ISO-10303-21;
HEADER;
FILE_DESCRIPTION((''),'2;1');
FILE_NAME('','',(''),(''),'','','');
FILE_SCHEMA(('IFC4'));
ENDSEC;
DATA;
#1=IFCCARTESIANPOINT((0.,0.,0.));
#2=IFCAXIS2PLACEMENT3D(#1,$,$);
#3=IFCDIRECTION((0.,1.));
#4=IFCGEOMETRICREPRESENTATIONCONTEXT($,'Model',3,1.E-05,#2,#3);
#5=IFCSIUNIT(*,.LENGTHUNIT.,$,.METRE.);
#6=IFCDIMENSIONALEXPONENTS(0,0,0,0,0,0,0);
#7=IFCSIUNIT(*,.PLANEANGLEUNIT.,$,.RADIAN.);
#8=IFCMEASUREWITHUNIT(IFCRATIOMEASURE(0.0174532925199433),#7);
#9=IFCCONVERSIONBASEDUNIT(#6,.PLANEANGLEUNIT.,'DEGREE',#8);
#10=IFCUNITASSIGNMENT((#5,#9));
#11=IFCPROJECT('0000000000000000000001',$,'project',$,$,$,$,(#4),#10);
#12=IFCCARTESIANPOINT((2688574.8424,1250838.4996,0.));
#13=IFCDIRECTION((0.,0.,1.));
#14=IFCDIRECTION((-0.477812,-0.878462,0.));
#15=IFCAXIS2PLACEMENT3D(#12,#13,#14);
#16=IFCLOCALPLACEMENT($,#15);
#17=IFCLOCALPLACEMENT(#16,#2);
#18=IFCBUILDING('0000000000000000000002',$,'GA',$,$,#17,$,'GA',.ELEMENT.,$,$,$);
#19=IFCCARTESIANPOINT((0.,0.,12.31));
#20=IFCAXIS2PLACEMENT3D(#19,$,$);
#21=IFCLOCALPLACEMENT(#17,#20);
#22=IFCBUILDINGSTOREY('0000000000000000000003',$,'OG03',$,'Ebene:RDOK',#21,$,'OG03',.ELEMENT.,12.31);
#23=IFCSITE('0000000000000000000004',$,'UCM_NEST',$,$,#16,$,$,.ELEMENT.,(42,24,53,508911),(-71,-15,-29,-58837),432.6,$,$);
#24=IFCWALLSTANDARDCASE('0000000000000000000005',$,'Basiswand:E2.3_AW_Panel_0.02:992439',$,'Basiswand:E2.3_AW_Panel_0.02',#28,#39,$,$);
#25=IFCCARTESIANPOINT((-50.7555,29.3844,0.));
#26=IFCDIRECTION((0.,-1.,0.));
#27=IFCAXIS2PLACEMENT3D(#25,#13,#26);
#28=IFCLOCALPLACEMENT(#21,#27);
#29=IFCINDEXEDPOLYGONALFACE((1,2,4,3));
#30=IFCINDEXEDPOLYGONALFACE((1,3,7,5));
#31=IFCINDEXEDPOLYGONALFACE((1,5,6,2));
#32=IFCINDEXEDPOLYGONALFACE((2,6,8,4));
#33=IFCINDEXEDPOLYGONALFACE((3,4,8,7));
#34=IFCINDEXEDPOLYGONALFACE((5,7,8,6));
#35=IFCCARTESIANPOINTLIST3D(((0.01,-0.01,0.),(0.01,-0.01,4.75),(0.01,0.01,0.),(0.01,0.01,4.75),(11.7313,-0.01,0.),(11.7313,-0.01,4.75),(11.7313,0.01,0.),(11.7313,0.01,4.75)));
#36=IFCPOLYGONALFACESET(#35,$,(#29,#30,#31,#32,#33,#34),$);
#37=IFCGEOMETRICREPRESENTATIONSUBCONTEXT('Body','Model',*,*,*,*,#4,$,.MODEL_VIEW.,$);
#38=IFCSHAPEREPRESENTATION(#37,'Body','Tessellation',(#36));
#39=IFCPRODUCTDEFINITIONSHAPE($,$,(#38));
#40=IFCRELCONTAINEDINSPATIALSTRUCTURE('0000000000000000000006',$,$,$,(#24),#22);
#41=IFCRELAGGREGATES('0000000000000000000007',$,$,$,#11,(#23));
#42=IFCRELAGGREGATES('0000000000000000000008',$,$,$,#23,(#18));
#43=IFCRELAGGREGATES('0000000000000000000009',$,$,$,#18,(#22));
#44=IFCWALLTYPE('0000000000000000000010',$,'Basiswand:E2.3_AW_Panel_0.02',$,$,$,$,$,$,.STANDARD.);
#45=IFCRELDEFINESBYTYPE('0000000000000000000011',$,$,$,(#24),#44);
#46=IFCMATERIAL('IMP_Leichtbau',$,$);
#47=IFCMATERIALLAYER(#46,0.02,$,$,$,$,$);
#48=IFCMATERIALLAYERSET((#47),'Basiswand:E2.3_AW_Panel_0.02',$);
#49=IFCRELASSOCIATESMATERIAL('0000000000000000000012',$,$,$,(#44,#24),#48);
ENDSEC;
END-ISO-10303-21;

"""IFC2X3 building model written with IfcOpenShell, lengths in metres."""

from ifc_helpers import new_model, entity, si_unit, converted_unit, direction, frame, frame_2d, origin, place, context, subcontext, project, spatial, rectangle, extrude, material, layer, layer_set, layer_usage, type_object, element, save


model = new_model("IFC2X3")

# Units and contexts
model_context = context("Model", 3, precision=1e-05, world=origin(), true_north=direction((0.0, 1.0)))
body_context = subcontext(model_context, "Body", "Model", "MODEL_VIEW")
ifc_project = project(units=[si_unit("LENGTHUNIT", "METRE"), converted_unit("PLANEANGLEUNIT", "DEGREE", entity("IfcRatioMeasure", 0.0174532925199433), si_unit("PLANEANGLEUNIT", "RADIAN"), dimensions=[0, 0, 0, 0, 0, 0, 0])], contexts=[model_context])

# Site, building, storey
site_placement = place(None, frame((2688574.8424, 1250838.4996, 0.0), z_axis=(0.0, 0.0, 1.0), x_axis=(-0.477812, -0.878462, 0.0)))
site = spatial("IfcSite", under=ifc_project, at=site_placement, Name="UCM_NEST", CompositionType="ELEMENT", RefLatitude=(42, 24, 53, 508911), RefLongitude=(-71, -15, -29, -58837), RefElevation=432.6)
building_placement = place(site_placement, origin())
building = spatial("IfcBuilding", under=site, at=building_placement, Name="GA", LongName="GA", CompositionType="ELEMENT")
storey_placement = place(building_placement, frame((0.0, 0.0, 12.31)))
storey = spatial("IfcBuildingStorey", under=building, at=storey_placement, Name="OG03", ObjectType="Ebene:RDOK", LongName="OG03", CompositionType="ELEMENT", Elevation=12.31)

# Wall
ifc_material_1 = material(Name="IMP_Leichtbau")
ifc_layer_1 = layer(ifc_material_1, 0.02)
ifc_layer_set_1 = layer_set([ifc_layer_1], Name="Basiswand:E2.3_AW_Panel_0.02")
wall_type_1 = type_object("IfcWallType", Name="Basiswand:E2.3_AW_Panel_0.02", PredefinedType="STANDARD", material=ifc_layer_set_1)
ifc_layer_usage_1 = layer_usage(ifc_layer_set_1, "AXIS2", "NEGATIVE", 0.01)
wall_1_placement = place(storey_placement, frame((-50.7555, 29.3844, 0.0), z_axis=(0.0, 0.0, 1.0), x_axis=(0.0, -1.0, 0.0)))
element("IfcWallStandardCase", 1, at=wall_1_placement, inside=storey, type_object=wall_type_1, material=ifc_layer_usage_1, Name="Basiswand:E2.3_AW_Panel_0.02:992439", ObjectType="Basiswand:E2.3_AW_Panel_0.02", context=body_context, shape_type="SweptSolid", body=[
    extrude(rectangle(XDim=11.7213, YDim=0.02, at=frame_2d((5.8706, 0.0), x_axis=(-1.0, 0.0))), origin(), (0.0, 0.0, 1.0), 4.75),
])

save(model, "model.ifc")
